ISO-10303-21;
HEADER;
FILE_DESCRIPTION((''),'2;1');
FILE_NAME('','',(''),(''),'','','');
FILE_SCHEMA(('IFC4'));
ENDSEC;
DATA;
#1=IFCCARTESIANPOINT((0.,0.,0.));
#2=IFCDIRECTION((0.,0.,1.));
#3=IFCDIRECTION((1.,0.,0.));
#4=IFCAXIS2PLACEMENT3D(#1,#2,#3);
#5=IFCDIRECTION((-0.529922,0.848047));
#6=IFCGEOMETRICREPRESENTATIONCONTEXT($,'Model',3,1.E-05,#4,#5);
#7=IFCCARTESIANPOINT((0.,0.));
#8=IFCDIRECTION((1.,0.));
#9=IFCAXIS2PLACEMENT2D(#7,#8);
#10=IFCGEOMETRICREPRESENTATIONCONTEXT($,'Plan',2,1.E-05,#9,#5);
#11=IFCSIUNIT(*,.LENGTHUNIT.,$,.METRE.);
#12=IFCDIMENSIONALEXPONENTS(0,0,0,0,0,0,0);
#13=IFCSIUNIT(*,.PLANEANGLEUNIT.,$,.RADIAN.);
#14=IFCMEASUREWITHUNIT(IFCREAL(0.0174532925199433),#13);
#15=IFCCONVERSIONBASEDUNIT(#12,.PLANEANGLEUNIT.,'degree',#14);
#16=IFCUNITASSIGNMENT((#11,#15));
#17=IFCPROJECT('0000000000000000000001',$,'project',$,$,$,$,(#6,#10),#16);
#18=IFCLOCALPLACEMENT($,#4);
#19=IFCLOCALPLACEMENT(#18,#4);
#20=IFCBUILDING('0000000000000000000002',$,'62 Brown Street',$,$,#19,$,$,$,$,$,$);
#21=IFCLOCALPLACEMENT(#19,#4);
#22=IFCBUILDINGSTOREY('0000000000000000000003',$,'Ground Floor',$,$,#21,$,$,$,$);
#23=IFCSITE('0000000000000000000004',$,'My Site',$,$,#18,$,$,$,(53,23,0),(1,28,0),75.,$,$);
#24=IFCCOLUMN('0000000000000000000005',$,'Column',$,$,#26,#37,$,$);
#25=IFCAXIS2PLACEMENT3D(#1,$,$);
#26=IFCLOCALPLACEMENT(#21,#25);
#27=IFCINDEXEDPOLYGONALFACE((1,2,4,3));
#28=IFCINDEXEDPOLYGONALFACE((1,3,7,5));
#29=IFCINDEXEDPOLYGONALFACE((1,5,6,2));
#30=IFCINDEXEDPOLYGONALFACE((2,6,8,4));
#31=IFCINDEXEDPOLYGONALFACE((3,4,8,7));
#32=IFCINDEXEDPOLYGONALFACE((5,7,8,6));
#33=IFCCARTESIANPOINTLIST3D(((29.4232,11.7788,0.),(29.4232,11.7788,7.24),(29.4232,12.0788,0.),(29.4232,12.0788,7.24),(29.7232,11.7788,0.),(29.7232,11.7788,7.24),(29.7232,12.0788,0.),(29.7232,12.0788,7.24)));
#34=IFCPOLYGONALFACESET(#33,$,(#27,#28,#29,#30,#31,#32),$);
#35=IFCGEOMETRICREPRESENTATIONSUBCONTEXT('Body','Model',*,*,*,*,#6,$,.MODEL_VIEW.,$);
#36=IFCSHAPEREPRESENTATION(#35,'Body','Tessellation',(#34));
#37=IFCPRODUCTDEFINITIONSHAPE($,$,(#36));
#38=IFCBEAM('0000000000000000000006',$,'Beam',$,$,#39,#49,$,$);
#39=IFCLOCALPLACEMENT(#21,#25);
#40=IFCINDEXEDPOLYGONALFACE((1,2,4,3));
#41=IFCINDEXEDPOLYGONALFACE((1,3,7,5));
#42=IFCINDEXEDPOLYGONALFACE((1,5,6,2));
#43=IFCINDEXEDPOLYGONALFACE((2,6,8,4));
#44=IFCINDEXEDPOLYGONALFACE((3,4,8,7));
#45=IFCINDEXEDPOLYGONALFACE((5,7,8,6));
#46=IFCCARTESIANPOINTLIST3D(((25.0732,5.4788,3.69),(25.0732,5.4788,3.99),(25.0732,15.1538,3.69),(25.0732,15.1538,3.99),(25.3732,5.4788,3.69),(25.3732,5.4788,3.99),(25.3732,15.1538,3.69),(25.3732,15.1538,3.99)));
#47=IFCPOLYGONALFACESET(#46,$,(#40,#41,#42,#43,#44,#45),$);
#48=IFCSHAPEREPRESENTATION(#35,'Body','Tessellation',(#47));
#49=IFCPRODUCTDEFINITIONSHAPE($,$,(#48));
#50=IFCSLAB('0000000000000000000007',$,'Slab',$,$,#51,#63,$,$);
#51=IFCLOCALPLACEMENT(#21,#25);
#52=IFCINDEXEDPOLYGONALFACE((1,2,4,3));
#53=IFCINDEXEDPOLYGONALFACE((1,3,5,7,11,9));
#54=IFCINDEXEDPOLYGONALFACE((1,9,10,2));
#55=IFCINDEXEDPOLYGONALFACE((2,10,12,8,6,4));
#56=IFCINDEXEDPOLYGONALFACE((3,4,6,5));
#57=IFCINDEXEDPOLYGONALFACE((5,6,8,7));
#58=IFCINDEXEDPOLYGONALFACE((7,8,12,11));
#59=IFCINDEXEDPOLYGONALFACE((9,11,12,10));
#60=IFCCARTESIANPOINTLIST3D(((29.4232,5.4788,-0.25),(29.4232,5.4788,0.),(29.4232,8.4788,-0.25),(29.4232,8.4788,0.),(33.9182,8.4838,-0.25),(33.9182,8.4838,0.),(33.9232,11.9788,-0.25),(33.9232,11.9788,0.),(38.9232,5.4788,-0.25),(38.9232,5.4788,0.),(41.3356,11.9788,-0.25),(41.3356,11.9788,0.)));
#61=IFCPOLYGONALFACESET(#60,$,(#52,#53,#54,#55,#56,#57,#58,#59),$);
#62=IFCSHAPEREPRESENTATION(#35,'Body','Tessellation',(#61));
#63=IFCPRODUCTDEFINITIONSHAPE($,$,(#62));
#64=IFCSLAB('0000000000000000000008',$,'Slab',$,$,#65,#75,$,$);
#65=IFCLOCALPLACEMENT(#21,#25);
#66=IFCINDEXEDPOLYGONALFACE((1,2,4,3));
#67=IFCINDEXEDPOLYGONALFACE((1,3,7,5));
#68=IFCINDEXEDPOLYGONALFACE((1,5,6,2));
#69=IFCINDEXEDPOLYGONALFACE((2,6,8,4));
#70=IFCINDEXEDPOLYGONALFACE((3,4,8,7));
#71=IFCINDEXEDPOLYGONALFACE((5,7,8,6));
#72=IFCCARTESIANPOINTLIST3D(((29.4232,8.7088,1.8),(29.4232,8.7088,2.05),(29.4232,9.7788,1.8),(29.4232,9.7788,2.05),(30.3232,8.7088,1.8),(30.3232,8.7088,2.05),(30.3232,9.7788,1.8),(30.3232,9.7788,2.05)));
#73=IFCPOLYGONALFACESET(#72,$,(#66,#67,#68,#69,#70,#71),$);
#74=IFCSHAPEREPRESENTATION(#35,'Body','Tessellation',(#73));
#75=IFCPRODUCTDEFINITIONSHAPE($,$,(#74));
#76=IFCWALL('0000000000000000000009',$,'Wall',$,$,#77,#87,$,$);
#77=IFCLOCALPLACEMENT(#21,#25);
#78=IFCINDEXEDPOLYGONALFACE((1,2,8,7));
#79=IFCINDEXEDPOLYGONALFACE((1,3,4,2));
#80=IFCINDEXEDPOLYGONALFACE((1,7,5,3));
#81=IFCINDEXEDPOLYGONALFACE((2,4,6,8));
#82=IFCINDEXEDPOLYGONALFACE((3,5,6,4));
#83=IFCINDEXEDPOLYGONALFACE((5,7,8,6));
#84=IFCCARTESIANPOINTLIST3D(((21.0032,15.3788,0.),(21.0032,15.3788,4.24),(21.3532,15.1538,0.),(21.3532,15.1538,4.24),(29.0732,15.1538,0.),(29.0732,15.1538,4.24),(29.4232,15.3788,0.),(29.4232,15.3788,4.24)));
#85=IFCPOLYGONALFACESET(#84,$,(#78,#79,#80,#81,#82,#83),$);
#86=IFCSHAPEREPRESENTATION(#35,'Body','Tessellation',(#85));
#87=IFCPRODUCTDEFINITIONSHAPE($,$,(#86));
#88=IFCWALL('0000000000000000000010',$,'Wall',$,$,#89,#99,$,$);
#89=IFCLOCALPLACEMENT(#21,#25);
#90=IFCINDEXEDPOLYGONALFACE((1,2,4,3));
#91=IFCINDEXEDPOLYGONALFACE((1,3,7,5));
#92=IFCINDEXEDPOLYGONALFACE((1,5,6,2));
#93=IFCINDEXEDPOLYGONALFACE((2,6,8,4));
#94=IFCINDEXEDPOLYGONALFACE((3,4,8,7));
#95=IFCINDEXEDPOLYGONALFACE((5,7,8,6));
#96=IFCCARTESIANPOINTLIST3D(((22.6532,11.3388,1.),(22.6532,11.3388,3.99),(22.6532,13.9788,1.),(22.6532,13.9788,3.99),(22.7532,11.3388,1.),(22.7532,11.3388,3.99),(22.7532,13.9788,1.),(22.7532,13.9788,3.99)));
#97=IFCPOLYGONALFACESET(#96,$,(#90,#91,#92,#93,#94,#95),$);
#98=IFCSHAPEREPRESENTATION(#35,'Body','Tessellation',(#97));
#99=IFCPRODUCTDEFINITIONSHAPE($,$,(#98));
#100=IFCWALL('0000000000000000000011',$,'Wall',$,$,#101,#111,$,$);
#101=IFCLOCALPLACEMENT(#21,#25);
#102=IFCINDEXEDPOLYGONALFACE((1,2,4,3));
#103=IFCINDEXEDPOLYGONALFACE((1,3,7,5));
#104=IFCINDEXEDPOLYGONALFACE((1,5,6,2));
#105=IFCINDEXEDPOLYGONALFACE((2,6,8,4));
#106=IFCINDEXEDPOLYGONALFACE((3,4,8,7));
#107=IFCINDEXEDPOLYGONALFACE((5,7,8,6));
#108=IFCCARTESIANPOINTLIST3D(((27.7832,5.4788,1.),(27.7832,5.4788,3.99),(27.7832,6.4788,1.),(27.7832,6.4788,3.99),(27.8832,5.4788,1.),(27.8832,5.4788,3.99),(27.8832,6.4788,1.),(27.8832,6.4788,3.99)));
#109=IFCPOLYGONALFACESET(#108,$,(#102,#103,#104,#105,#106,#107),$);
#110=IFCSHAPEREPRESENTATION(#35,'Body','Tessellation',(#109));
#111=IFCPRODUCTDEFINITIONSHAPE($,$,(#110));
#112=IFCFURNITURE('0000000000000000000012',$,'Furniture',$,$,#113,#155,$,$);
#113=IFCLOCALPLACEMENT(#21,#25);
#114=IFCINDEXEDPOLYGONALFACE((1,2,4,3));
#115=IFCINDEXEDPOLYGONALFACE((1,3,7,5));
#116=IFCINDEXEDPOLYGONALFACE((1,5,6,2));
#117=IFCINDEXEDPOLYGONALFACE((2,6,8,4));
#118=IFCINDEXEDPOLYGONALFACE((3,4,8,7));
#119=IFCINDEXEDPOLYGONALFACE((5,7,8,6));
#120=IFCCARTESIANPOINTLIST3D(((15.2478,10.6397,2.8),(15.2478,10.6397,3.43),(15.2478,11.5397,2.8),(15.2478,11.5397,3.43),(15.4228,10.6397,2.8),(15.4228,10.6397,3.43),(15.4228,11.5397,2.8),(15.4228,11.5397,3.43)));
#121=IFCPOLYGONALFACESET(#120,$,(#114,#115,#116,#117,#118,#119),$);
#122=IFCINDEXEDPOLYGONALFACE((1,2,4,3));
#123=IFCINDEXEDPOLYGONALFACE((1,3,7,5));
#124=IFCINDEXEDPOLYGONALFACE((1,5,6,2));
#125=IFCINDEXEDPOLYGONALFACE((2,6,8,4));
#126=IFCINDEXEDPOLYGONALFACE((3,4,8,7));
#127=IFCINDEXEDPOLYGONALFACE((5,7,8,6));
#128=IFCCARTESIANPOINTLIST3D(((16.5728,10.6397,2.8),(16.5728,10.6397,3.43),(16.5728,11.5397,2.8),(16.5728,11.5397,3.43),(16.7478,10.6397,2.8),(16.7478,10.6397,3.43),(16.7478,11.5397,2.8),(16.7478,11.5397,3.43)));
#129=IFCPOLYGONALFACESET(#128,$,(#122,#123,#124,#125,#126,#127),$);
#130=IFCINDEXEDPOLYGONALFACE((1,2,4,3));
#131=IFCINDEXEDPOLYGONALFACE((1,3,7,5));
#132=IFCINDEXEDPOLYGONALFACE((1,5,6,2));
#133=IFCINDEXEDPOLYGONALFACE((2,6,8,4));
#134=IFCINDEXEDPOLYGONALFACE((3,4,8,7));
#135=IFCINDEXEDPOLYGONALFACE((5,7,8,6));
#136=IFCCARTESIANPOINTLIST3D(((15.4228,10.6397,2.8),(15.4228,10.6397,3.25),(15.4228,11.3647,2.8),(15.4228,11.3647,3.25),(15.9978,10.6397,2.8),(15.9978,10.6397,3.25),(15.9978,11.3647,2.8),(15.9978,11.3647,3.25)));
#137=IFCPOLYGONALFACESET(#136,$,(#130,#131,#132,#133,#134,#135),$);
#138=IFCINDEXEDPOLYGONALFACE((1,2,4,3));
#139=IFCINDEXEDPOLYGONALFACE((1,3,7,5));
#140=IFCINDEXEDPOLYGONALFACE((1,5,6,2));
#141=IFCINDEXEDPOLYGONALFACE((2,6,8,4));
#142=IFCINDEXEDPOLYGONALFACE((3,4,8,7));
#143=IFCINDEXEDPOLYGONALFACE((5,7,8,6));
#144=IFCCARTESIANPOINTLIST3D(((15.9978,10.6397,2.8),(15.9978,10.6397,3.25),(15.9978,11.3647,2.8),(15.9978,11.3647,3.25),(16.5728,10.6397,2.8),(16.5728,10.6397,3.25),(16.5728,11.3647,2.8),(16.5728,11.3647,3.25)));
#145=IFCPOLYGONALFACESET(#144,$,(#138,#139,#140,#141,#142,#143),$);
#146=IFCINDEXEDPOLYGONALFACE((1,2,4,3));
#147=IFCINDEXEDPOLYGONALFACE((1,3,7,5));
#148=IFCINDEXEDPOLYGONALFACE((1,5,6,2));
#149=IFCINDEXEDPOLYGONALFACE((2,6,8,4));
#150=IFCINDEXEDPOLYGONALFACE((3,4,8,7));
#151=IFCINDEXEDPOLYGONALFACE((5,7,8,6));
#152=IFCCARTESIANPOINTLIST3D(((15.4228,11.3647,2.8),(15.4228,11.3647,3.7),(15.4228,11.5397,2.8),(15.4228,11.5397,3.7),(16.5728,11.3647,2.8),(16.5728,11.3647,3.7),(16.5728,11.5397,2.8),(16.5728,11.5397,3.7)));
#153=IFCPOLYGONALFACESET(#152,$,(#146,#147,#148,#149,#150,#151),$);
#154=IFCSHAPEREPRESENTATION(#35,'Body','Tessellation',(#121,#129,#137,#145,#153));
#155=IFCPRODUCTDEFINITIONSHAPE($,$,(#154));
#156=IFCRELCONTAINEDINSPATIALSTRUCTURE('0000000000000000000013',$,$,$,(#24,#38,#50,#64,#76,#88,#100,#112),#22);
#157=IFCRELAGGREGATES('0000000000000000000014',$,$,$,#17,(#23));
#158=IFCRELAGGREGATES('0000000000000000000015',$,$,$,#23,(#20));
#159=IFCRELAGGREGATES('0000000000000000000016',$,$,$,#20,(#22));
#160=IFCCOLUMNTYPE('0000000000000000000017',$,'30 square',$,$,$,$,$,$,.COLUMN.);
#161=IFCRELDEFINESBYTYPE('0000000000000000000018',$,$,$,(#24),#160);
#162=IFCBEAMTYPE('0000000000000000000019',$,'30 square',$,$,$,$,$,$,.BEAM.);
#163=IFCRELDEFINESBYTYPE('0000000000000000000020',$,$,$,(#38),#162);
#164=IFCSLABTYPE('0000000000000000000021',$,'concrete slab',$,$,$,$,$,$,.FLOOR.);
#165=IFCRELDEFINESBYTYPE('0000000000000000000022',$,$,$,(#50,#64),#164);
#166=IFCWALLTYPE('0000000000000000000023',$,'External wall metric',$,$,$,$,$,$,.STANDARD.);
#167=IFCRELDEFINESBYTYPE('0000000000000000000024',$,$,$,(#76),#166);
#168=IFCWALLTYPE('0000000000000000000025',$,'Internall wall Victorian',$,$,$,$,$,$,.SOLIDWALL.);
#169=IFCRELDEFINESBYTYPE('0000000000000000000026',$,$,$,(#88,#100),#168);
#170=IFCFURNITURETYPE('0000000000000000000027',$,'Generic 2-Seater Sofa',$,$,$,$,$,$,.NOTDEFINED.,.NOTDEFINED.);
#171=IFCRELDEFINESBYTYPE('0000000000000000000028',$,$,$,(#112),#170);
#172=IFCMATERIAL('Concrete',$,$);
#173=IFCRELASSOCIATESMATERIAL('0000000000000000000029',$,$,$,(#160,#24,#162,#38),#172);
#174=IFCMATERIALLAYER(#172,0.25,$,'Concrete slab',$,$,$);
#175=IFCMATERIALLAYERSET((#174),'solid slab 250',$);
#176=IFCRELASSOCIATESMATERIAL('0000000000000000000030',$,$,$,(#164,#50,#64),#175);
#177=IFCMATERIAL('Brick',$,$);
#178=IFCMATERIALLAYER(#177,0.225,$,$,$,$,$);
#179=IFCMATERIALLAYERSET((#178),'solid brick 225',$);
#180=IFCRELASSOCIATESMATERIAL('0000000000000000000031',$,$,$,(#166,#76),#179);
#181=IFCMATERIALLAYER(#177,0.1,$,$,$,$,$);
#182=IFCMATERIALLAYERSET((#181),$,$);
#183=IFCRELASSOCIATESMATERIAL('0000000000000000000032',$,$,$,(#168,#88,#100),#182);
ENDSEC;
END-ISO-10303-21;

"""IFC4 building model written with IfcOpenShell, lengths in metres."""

from ifc_helpers import new_model, entity, si_unit, converted_unit, direction, frame, origin_with_axes, origin_2d_with_axis, place, context, subcontext, project, spatial, line, indexed_curve, rectangle, outline, extrude, clip, halfspace, shape, source, transform, mapped, material, layer, layer_set, layer_usage, material_profile, profile_set, profile_usage, type_object, type_shapes, element, save


model = new_model("IFC4")

# Units and contexts
model_context = context("Model", 3, precision=1e-05, world=origin_with_axes(), true_north=direction((-0.529922, 0.848047)))
plan_context = context("Plan", 2, precision=1e-05, world=origin_2d_with_axis(), true_north=direction((-0.529922, 0.848047)))
body_context_1 = subcontext(model_context, "Body", "Model", "MODEL_VIEW")
body_context_2 = subcontext(plan_context, "Body", "Plan", "PLAN_VIEW")
ifc_project = project(units=[si_unit("LENGTHUNIT", "METRE"), converted_unit("PLANEANGLEUNIT", "degree", entity("IfcReal", 0.0174532925199433), si_unit("PLANEANGLEUNIT", "RADIAN"), dimensions=[0, 0, 0, 0, 0, 0, 0])], contexts=[model_context, plan_context])

# Site, building, storey
site_placement = place(None, origin_with_axes())
site = spatial("IfcSite", under=ifc_project, at=site_placement, Name="My Site", RefLatitude=(53, 23, 0), RefLongitude=(1, 28, 0), RefElevation=75.0)
building_placement = place(site_placement, origin_with_axes())
building = spatial("IfcBuilding", under=site, at=building_placement, Name="62 Brown Street")
storey_placement = place(building_placement, origin_with_axes())
storey = spatial("IfcBuildingStorey", under=building, at=storey_placement, Name="Ground Floor")

# Column
ifc_material_1 = material(Name="Concrete")
ifc_material_profile_1 = material_profile(ifc_material_1, rectangle(XDim=0.3, YDim=0.3))
ifc_profile_set_1 = profile_set([ifc_material_profile_1])
ifc_profile_usage_1 = profile_usage(ifc_profile_set_1, cardinal=5)
column_type = type_object("IfcColumnType", Name="30 square", PredefinedType="COLUMN", material=ifc_profile_set_1)
column_1_placement = place(storey_placement, frame((29.5732, 11.9288, 0.0), z_axis=(0.0, 0.0, 1.0), x_axis=(1.0, 0.0, 0.0)))
element("IfcColumn", 1, at=column_1_placement, inside=storey, type_object=column_type, material=ifc_profile_usage_1, Name="Column", context=body_context_1, shape_type="SweptSolid", body=[
    extrude(rectangle(XDim=0.3, YDim=0.3), origin_with_axes(), (0.0, 0.0, 1.0), 7.24),
])

# Beam
ifc_material_profile_2 = material_profile(ifc_material_1, rectangle(XDim=0.3, YDim=0.3))
ifc_profile_set_2 = profile_set([ifc_material_profile_2])
ifc_profile_usage_2 = profile_usage(ifc_profile_set_2, cardinal=5)
beam_type = type_object("IfcBeamType", Name="30 square", PredefinedType="BEAM", material=ifc_profile_set_2)
beam_placement = place(storey_placement, frame((25.2232, 5.4788, 3.84), z_axis=(0.0, 1.0, 0.0), x_axis=(-1.0, 0.0, 0.0)))
element("IfcBeam", 2, at=beam_placement, inside=storey, type_object=beam_type, material=ifc_profile_usage_2, Name="Beam", context=body_context_1, shape_type="SweptSolid", body=[
    extrude(rectangle(XDim=0.3, YDim=0.3), origin_with_axes(), (0.0, 0.0, 1.0), 9.675),
])

# Slabs
ifc_layer_1 = layer(ifc_material_1, 0.25, Name="Concrete slab")
ifc_layer_set_1 = layer_set([ifc_layer_1], Name="solid slab 250")
ifc_layer_usage_1 = layer_usage(ifc_layer_set_1, "AXIS3", "POSITIVE", 0.0)
slab_type = type_object("IfcSlabType", Name="concrete slab", PredefinedType="FLOOR", material=ifc_layer_set_1)
slab_1_placement = place(storey_placement, frame((29.4232, 5.4788, -0.25), z_axis=(0.0, 0.0, 1.0), x_axis=(1.0, 0.0, 0.0)))
element("IfcSlab", 3, at=slab_1_placement, inside=storey, type_object=slab_type, material=ifc_layer_usage_1, Name="Slab", context=body_context_1, shape_type="SweptSolid", body=[
    extrude(outline(indexed_curve([(0.0, 0.0), (9.5, 0.0), (11.9124, 6.5), (0.0, 3.0), (4.5, 6.5), (4.495, 3.005)], segments=[line(1, 2), line(2, 3), line(3, 5), line(5, 6), line(6, 4), line(4, 1)], self_intersect=False)), None, (0.0, 0.0, 1.0), 0.25),
])
ifc_layer_usage_2 = layer_usage(ifc_layer_set_1, "AXIS3", "POSITIVE", 0.0)
slab_2_placement = place(storey_placement, frame((29.4232, 8.7088, 1.8), z_axis=(0.0, 0.0, 1.0), x_axis=(1.0, 0.0, 0.0)))
element("IfcSlab", 4, at=slab_2_placement, inside=storey, type_object=slab_type, material=ifc_layer_usage_2, Name="Slab", context=body_context_1, shape_type="SweptSolid", body=[
    extrude(outline(indexed_curve([(0.9, 1.07), (0.9, 0.0), (0.0, 0.0), (0.0, 1.07)], segments=[line(3, 2), line(2, 1), line(1, 4), line(4, 3)], self_intersect=False)), None, (0.0, 0.0, 1.0), 0.25),
])

# Walls
ifc_material_2 = material(Name="Brick")
ifc_layer_2 = layer(ifc_material_2, 0.225)
ifc_layer_set_2 = layer_set([ifc_layer_2], Name="solid brick 225")
wall_type_1 = type_object("IfcWallType", Name="External wall metric", PredefinedType="STANDARD", material=ifc_layer_set_2)
ifc_layer_usage_3 = layer_usage(ifc_layer_set_2, "AXIS2", "POSITIVE", 0.0)
wall_1_placement = place(storey_placement, frame((29.4232, 15.3788, 0.0), z_axis=(0.0, 0.0, 1.0), x_axis=(-1.0, 0.0, 0.0)))
element("IfcWall", 5, at=wall_1_placement, inside=storey, type_object=wall_type_1, material=ifc_layer_usage_3, Name="Wall", context=body_context_1, shape_type="Clipping", body=[
    clip(clip(extrude(outline(indexed_curve([(0.0, 0.0), (0.0, 0.225), (8.42, 0.225), (8.42, 0.0), (0.0, 0.0)], self_intersect=False)), origin_with_axes(), (0.0, 0.0, 1.0), 4.24), halfspace(frame((8.42, 0.0, 0.0), z_axis=(0.540756, 0.841179, 0.0), x_axis=(-0.841179, 0.540756, 0.0)), False)), halfspace(frame((0.0, 0.0, 0.0), z_axis=(-0.540758, 0.841178, 0.0), x_axis=(0.841178, 0.540758, 0.0)), False)),
])
ifc_layer_3 = layer(ifc_material_2, 0.1)
ifc_layer_set_3 = layer_set([ifc_layer_3])
ifc_layer_usage_4 = layer_usage(ifc_layer_set_3, "AXIS2", "POSITIVE", 0.0)
wall_type_2 = type_object("IfcWallType", Name="Internall wall Victorian", PredefinedType="SOLIDWALL", material=ifc_layer_set_3)
wall_2_placement = place(storey_placement, frame((22.7532, 11.3388, 1.0), z_axis=(0.0, 0.0, 1.0), x_axis=(0.0, 1.0, 0.0)))
element("IfcWall", 6, at=wall_2_placement, inside=storey, type_object=wall_type_2, material=ifc_layer_usage_4, Name="Wall", context=body_context_1, shape_type="SweptSolid", body=[
    extrude(outline(indexed_curve([(0.0, 0.0), (0.0, 0.1), (2.64, 0.1), (2.64, 0.0), (0.0, 0.0)], self_intersect=False)), origin_with_axes(), (0.0, 0.0, 1.0), 2.99),
])
ifc_layer_usage_5 = layer_usage(ifc_layer_set_3, "AXIS2", "POSITIVE", 0.0)
wall_3_placement = place(storey_placement, frame((27.8832, 5.4788, 1.0), z_axis=(0.0, 0.0, 1.0), x_axis=(0.0, 1.0, 0.0)))
element("IfcWall", 7, at=wall_3_placement, inside=storey, type_object=wall_type_2, material=ifc_layer_usage_5, Name="Wall", context=body_context_1, shape_type="SweptSolid", body=[
    extrude(outline(indexed_curve([(0.0, 0.0), (0.0, 0.1), (1.0, 0.1), (1.0, 0.0), (0.0, 0.0)], self_intersect=False)), origin_with_axes(), (0.0, 0.0, 1.0), 2.99),
])

# Furniture
furniture_type_1 = type_object("IfcFurnitureType", Name="Generic 2-Seater Sofa", AssemblyPlace="NOTDEFINED", PredefinedType="NOTDEFINED")
shared_shape_1 = source(origin_with_axes(), body_context_1, "Body", "SweptSolid", [
    extrude(outline(indexed_curve([(0.0, 0.0), (0.175, 0.0), (0.175, 0.9), (0.0, 0.9)], segments=[line(1, 2, 3, 4, 1)])), frame((-0.75, -0.9, 0.0), z_axis=(0.0, 0.0, 1.0), x_axis=(1.0, 0.0, 0.0)), (0.0, 0.0, 1.0), 0.63),
    extrude(outline(indexed_curve([(0.0, 0.0), (0.175, 0.0), (0.175, 0.9), (0.0, 0.9)], segments=[line(1, 2, 3, 4, 1)])), frame((0.575, -0.9, 0.0), z_axis=(0.0, 0.0, 1.0), x_axis=(1.0, 0.0, 0.0)), (0.0, 0.0, 1.0), 0.63),
    extrude(outline(indexed_curve([(0.175, 0.0), (0.75, 0.0), (0.75, 0.725), (0.175, 0.725)], segments=[line(1, 2, 3, 4, 1)])), frame((-0.75, -0.9, 0.0), z_axis=(0.0, 0.0, 1.0), x_axis=(1.0, 0.0, 0.0)), (0.0, 0.0, 1.0), 0.45),
    extrude(outline(indexed_curve([(0.75, 0.0), (1.325, 0.0), (1.325, 0.725), (0.75, 0.725)], segments=[line(1, 2, 3, 4, 1)])), frame((-0.75, -0.9, 0.0), z_axis=(0.0, 0.0, 1.0), x_axis=(1.0, 0.0, 0.0)), (0.0, 0.0, 1.0), 0.45),
    extrude(outline(indexed_curve([(0.175, 0.725), (1.325, 0.725), (1.325, 0.9), (0.175, 0.9)], segments=[line(1, 2, 3, 4, 1)])), frame((-0.75, -0.9, 0.0), z_axis=(0.0, 0.0, 1.0), x_axis=(1.0, 0.0, 0.0)), (0.0, 0.0, 1.0), 0.9),
])
shared_shape_2 = source(origin_with_axes(), body_context_2, "Body", "Curve2D", [
    entity("IfcIndexedPolyCurve", entity("IfcCartesianPointList2D", [[-0.75, -0.9], [-0.575, -0.9], [-0.575, 0.0], [-0.75, 0.0]]), [entity("IfcLineIndex", [1, 2, 3, 4, 1])]),
    entity("IfcIndexedPolyCurve", entity("IfcCartesianPointList2D", [[0.575, -0.9], [0.75, -0.9], [0.75, 0.0], [0.575, 0.0]]), [entity("IfcLineIndex", [1, 2, 3, 4, 1])]),
    entity("IfcIndexedPolyCurve", entity("IfcCartesianPointList2D", [[-0.575, -0.9], [0.0, -0.9], [0.0, -0.175], [-0.575, -0.175]]), [entity("IfcLineIndex", [1, 2, 3, 4, 1])]),
    entity("IfcIndexedPolyCurve", entity("IfcCartesianPointList2D", [[0.0, -0.9], [0.575, -0.9], [0.575, -0.175], [0.0, -0.175]]), [entity("IfcLineIndex", [1, 2, 3, 4, 1])]),
    entity("IfcIndexedPolyCurve", entity("IfcCartesianPointList2D", [[-0.575, -0.175], [0.575, -0.175], [0.575, 0.0], [-0.575, 0.0]]), [entity("IfcLineIndex", [1, 2, 3, 4, 1])]),
])
type_shapes(furniture_type_1, [shared_shape_1, shared_shape_2])
furniture_1_placement = place(storey_placement, frame((15.9978, 11.5397, 2.8), z_axis=(0.0, 0.0, 1.0), x_axis=(1.0, 0.0, 0.0)))
element("IfcFurniture", 8, at=furniture_1_placement, inside=storey, type_object=furniture_type_1, Name="Furniture", shapes=[
    shape(body_context_1, "Body", "MappedRepresentation", [mapped(shared_shape_1, transform((0.0, 0.0, 0.0), x_axis=(1.0, 0.0, 0.0), y_axis=(0.0, 1.0, 0.0), z_axis=(0.0, 0.0, 1.0), scale=1.0))]),
    shape(body_context_2, "Body", "MappedRepresentation", [mapped(shared_shape_2, transform((0.0, 0.0, 0.0), x_axis=(1.0, 0.0, 0.0), y_axis=(0.0, 1.0, 0.0), z_axis=(0.0, 0.0, 1.0), scale=1.0))]),
])

save(model, "model.ifc")
